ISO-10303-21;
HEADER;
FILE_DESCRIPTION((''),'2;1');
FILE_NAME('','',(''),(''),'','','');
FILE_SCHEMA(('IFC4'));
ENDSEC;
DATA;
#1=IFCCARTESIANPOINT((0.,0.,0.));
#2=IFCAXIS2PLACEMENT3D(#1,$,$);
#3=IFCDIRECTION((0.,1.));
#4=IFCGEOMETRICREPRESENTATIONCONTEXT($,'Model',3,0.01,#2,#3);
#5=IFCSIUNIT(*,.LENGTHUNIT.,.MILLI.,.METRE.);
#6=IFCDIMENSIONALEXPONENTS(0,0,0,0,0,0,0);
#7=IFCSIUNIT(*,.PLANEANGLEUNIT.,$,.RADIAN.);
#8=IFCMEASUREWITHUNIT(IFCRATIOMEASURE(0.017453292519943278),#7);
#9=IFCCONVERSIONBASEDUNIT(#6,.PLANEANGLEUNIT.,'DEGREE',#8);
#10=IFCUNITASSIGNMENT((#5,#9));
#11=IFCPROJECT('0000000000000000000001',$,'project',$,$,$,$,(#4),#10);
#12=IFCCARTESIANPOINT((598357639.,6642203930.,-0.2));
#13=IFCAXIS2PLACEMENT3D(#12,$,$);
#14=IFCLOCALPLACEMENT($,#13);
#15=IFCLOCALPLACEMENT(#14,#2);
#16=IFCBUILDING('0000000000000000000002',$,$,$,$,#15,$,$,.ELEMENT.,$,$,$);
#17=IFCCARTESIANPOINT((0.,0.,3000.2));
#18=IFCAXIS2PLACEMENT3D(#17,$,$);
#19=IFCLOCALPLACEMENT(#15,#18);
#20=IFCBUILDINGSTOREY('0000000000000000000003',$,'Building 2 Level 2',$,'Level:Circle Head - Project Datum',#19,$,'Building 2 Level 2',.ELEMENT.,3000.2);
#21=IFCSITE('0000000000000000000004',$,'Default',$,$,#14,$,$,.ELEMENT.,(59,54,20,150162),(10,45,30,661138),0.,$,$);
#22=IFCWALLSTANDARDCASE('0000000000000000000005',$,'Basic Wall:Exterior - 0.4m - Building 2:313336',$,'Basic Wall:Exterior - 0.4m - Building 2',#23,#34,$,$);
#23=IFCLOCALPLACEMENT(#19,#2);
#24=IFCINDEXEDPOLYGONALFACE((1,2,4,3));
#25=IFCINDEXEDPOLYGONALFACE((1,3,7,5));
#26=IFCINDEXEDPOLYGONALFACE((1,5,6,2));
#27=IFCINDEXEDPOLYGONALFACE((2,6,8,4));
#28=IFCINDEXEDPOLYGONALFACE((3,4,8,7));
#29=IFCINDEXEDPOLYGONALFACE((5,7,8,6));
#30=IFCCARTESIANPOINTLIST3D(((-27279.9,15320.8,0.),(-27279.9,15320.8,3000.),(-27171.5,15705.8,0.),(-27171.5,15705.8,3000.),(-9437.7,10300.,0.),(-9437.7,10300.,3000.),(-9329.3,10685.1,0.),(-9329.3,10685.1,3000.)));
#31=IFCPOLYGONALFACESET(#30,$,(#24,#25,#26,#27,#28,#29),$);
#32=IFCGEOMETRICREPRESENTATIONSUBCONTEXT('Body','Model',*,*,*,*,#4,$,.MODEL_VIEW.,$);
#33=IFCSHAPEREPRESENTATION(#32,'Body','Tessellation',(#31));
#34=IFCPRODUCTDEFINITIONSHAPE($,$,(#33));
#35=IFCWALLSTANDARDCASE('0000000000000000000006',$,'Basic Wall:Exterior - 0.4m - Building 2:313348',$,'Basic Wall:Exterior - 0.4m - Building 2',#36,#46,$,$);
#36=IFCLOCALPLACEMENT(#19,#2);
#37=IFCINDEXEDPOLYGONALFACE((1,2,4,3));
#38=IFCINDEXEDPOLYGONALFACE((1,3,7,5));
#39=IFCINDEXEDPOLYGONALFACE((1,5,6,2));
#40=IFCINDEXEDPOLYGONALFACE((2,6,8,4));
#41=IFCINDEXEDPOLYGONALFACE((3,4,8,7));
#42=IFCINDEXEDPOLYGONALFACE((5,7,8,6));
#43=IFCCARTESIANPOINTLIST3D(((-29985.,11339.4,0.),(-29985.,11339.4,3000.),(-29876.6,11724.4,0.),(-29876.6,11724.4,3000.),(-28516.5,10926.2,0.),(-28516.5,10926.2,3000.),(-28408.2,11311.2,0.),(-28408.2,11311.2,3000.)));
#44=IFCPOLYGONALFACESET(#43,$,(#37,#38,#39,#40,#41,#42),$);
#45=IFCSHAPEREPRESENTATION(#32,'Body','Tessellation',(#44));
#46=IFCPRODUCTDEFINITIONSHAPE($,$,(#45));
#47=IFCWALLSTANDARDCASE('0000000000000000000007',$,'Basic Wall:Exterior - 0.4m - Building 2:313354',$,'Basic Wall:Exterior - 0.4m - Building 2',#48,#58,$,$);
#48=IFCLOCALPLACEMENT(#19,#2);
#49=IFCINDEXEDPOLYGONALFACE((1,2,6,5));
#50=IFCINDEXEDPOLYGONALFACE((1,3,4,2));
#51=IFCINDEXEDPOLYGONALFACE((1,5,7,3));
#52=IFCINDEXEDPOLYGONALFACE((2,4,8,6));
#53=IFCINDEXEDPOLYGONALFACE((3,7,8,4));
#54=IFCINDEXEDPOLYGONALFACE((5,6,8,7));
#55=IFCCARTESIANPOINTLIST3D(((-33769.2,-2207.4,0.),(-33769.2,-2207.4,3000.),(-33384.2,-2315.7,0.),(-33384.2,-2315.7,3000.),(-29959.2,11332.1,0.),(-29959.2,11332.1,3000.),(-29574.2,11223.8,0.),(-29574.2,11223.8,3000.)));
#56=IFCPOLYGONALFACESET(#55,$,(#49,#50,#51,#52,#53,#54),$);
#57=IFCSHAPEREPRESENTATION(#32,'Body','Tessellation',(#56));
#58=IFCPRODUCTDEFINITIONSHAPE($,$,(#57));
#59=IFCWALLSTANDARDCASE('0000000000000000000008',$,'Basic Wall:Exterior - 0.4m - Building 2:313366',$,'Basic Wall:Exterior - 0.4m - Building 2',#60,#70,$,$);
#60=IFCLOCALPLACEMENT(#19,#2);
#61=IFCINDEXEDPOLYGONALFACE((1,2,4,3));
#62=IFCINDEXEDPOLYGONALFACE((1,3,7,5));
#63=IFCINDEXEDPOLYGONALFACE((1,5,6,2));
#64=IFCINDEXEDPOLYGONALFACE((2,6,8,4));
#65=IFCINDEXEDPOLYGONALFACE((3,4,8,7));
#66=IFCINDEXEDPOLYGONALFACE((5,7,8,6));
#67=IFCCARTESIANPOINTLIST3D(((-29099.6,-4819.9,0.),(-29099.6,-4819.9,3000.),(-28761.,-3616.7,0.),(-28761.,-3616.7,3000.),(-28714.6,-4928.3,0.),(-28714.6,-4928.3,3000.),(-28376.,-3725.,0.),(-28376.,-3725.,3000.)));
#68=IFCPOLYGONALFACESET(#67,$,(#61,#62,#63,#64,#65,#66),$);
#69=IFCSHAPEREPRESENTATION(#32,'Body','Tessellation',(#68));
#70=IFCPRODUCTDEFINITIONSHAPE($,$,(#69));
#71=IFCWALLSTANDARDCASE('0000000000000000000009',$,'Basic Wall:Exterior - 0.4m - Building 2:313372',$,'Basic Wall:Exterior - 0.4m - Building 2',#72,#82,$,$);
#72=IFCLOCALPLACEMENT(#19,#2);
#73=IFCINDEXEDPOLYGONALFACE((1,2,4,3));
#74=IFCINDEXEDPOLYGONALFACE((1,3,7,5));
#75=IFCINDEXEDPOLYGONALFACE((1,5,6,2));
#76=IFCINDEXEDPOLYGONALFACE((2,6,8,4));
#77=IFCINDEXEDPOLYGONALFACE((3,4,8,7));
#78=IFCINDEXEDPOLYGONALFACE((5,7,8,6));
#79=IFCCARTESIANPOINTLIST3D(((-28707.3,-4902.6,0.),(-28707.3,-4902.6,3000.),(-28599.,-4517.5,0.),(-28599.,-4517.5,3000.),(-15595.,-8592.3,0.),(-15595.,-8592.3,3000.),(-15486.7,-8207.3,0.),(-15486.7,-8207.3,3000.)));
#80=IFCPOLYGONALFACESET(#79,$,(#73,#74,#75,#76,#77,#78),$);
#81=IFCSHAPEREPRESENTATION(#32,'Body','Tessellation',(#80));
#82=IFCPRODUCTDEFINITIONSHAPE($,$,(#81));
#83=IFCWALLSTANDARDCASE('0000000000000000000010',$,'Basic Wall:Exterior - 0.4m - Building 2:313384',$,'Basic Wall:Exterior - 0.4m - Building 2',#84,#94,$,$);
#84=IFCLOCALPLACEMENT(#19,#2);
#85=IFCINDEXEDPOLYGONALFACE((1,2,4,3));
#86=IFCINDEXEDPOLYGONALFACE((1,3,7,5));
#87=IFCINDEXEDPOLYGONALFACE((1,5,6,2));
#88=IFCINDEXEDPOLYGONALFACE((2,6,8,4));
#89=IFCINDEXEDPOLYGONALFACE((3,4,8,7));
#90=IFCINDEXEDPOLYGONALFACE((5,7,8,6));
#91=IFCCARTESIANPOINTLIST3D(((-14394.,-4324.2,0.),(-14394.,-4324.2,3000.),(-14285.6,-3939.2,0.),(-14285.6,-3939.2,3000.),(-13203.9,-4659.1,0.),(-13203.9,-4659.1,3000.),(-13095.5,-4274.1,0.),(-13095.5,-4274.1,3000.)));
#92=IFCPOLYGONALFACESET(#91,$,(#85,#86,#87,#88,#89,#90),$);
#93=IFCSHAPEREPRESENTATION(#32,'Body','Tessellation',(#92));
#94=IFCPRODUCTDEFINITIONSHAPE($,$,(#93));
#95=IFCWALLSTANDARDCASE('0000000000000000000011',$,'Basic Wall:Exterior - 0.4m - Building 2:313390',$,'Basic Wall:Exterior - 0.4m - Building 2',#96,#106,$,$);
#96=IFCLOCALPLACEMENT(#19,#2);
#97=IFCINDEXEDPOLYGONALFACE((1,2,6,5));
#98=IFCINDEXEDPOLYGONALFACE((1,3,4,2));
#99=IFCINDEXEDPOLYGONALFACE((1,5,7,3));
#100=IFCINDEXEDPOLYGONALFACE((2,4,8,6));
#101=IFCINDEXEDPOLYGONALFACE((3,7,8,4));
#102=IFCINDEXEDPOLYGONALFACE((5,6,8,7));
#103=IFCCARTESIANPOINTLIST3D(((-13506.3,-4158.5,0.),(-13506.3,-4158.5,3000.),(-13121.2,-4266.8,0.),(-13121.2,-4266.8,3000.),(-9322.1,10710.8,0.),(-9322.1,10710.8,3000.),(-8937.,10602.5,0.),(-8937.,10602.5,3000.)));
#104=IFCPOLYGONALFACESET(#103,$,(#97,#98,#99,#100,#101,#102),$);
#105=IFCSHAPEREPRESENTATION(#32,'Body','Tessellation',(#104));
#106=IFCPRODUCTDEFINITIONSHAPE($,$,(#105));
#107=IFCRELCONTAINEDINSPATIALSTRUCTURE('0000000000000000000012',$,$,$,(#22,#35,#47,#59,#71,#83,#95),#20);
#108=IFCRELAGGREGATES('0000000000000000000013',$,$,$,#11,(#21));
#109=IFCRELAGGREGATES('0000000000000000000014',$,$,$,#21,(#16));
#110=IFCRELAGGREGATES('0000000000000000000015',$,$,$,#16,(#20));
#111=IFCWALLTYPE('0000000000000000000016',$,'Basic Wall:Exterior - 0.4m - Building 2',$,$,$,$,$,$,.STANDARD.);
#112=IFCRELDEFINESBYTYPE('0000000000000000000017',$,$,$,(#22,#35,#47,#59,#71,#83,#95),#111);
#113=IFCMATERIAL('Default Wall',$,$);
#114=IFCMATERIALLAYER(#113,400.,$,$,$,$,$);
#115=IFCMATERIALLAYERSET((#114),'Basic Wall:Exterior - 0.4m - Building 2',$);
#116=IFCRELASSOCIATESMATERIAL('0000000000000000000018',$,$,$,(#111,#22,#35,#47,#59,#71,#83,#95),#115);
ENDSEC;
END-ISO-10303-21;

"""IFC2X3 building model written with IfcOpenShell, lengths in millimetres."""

from ifc_helpers import new_model, entity, si_unit, converted_unit, direction, frame, frame_2d, origin, place, context, subcontext, project, spatial, rectangle, extrude, material, layer, layer_set, layer_usage, type_object, element, save


model = new_model("IFC2X3")

# Units and contexts
model_context = context("Model", 3, precision=0.01, world=origin(), true_north=direction((0.0, 1.0)))
body_context = subcontext(model_context, "Body", "Model", "MODEL_VIEW")
ifc_project = project(units=[si_unit("LENGTHUNIT", "METRE", prefix="MILLI"), converted_unit("PLANEANGLEUNIT", "DEGREE", entity("IfcRatioMeasure", 0.017453292519943278), si_unit("PLANEANGLEUNIT", "RADIAN"), dimensions=[0, 0, 0, 0, 0, 0, 0])], contexts=[model_context])

# Site, building, storey
site_placement = place(None, frame((598357639.0, 6642203930.0, -0.2)))
site = spatial("IfcSite", under=ifc_project, at=site_placement, Name="Default", CompositionType="ELEMENT", RefLatitude=(59, 54, 20, 150162), RefLongitude=(10, 45, 30, 661138), RefElevation=0.0)
building_placement = place(site_placement, origin())
building = spatial("IfcBuilding", under=site, at=building_placement, CompositionType="ELEMENT")
storey_placement = place(building_placement, frame((0.0, 0.0, 3000.2)))
storey = spatial("IfcBuildingStorey", under=building, at=storey_placement, Name="Building 2 Level 2", ObjectType="Level:Circle Head - Project Datum", LongName="Building 2 Level 2", CompositionType="ELEMENT", Elevation=3000.2)

# Walls
ifc_material_1 = material(Name="Default Wall")
ifc_layer_1 = layer(ifc_material_1, 400.0)
ifc_layer_set_1 = layer_set([ifc_layer_1], Name="Basic Wall:Exterior - 0.4m - Building 2")
ifc_layer_usage_1 = layer_usage(ifc_layer_set_1, "AXIS2", "POSITIVE", -200.0)
wall_type = type_object("IfcWallType", Name="Basic Wall:Exterior - 0.4m - Building 2", PredefinedType="STANDARD", material=ifc_layer_set_1)
wall_1_placement = place(storey_placement, frame((-9383.5, 10492.6, 0.0), z_axis=(0.0, 0.0, 1.0), x_axis=(-0.962614, 0.270878, 0.0)))
element("IfcWallStandardCase", 1, at=wall_1_placement, inside=storey, type_object=wall_type, material=ifc_layer_usage_1, Name="Basic Wall:Exterior - 0.4m - Building 2:313336", ObjectType="Basic Wall:Exterior - 0.4m - Building 2", context=body_context, shape_type="SweptSolid", body=[
    extrude(rectangle(XDim=18535.1, YDim=400.0, at=frame_2d((9267.6, 0.0), x_axis=(-1.0, 0.0))), origin(), (0.0, 0.0, 1.0), 3000.0),
])
wall_2_placement = place(storey_placement, frame((-28462.3, 11118.7, 0.0), z_axis=(0.0, 0.0, 1.0), x_axis=(-0.962614, 0.270878, 0.0)))
element("IfcWallStandardCase", 2, at=wall_2_placement, inside=storey, type_object=wall_type, material=ifc_layer_usage_1, Name="Basic Wall:Exterior - 0.4m - Building 2:313348", ObjectType="Basic Wall:Exterior - 0.4m - Building 2", context=body_context, shape_type="SweptSolid", body=[
    extrude(rectangle(XDim=1525.5, YDim=400.0, at=frame_2d((762.7, 0.0), x_axis=(-1.0, 0.0))), origin(), (0.0, 0.0, 1.0), 3000.0),
])
wall_3_placement = place(storey_placement, frame((-29766.7, 11278.0, 0.0), z_axis=(0.0, 0.0, 1.0), x_axis=(-0.270878, -0.962614, 0.0)))
element("IfcWallStandardCase", 3, at=wall_3_placement, inside=storey, type_object=wall_type, material=ifc_layer_usage_1, Name="Basic Wall:Exterior - 0.4m - Building 2:313354", ObjectType="Basic Wall:Exterior - 0.4m - Building 2", context=body_context, shape_type="SweptSolid", body=[
    extrude(rectangle(XDim=14065.4, YDim=400.0, at=frame_2d((7032.7, 0.0), x_axis=(-1.0, 0.0))), origin(), (0.0, 0.0, 1.0), 3000.0),
])
wall_4_placement = place(storey_placement, frame((-28568.5, -3670.8, 0.0), z_axis=(0.0, 0.0, 1.0), x_axis=(-0.270878, -0.962614, 0.0)))
element("IfcWallStandardCase", 4, at=wall_4_placement, inside=storey, type_object=wall_type, material=ifc_layer_usage_1, Name="Basic Wall:Exterior - 0.4m - Building 2:313366", ObjectType="Basic Wall:Exterior - 0.4m - Building 2", context=body_context, shape_type="SweptSolid", body=[
    extrude(rectangle(XDim=1250.0, YDim=400.0, at=frame_2d((625.0, 0.0), x_axis=(-1.0, 0.0))), origin(), (0.0, 0.0, 1.0), 3000.0),
])
wall_5_placement = place(storey_placement, frame((-28653.2, -4710.0, 0.0), z_axis=(0.0, 0.0, 1.0), x_axis=(0.962614, -0.270878, 0.0)))
element("IfcWallStandardCase", 5, at=wall_5_placement, inside=storey, type_object=wall_type, material=ifc_layer_usage_1, Name="Basic Wall:Exterior - 0.4m - Building 2:313372", ObjectType="Basic Wall:Exterior - 0.4m - Building 2", context=body_context, shape_type="SweptSolid", body=[
    extrude(rectangle(XDim=13621.6, YDim=400.0, at=frame_2d((6810.8, 0.0), x_axis=(-1.0, 0.0))), origin(), (0.0, 0.0, 1.0), 3000.0),
])
wall_6_placement = place(storey_placement, frame((-14339.8, -4131.7, 0.0), z_axis=(0.0, 0.0, 1.0), x_axis=(0.962614, -0.270878, 0.0)))
element("IfcWallStandardCase", 6, at=wall_6_placement, inside=storey, type_object=wall_type, material=ifc_layer_usage_1, Name="Basic Wall:Exterior - 0.4m - Building 2:313384", ObjectType="Basic Wall:Exterior - 0.4m - Building 2", context=body_context, shape_type="SweptSolid", body=[
    extrude(rectangle(XDim=1236.4, YDim=400.0, at=frame_2d((618.2, 0.0), x_axis=(-1.0, 0.0))), origin(), (0.0, 0.0, 1.0), 3000.0),
])
wall_7_placement = place(storey_placement, frame((-13313.8, -4212.6, 0.0), z_axis=(0.0, 0.0, 1.0), x_axis=(0.270878, 0.962614, 0.0)))
element("IfcWallStandardCase", 7, at=wall_7_placement, inside=storey, type_object=wall_type, material=ifc_layer_usage_1, Name="Basic Wall:Exterior - 0.4m - Building 2:313390", ObjectType="Basic Wall:Exterior - 0.4m - Building 2", context=body_context, shape_type="SweptSolid", body=[
    extrude(rectangle(XDim=15446.8, YDim=400.0, at=frame_2d((7723.4, 0.0), x_axis=(-1.0, 0.0))), origin(), (0.0, 0.0, 1.0), 3000.0),
])

save(model, "model.ifc")
